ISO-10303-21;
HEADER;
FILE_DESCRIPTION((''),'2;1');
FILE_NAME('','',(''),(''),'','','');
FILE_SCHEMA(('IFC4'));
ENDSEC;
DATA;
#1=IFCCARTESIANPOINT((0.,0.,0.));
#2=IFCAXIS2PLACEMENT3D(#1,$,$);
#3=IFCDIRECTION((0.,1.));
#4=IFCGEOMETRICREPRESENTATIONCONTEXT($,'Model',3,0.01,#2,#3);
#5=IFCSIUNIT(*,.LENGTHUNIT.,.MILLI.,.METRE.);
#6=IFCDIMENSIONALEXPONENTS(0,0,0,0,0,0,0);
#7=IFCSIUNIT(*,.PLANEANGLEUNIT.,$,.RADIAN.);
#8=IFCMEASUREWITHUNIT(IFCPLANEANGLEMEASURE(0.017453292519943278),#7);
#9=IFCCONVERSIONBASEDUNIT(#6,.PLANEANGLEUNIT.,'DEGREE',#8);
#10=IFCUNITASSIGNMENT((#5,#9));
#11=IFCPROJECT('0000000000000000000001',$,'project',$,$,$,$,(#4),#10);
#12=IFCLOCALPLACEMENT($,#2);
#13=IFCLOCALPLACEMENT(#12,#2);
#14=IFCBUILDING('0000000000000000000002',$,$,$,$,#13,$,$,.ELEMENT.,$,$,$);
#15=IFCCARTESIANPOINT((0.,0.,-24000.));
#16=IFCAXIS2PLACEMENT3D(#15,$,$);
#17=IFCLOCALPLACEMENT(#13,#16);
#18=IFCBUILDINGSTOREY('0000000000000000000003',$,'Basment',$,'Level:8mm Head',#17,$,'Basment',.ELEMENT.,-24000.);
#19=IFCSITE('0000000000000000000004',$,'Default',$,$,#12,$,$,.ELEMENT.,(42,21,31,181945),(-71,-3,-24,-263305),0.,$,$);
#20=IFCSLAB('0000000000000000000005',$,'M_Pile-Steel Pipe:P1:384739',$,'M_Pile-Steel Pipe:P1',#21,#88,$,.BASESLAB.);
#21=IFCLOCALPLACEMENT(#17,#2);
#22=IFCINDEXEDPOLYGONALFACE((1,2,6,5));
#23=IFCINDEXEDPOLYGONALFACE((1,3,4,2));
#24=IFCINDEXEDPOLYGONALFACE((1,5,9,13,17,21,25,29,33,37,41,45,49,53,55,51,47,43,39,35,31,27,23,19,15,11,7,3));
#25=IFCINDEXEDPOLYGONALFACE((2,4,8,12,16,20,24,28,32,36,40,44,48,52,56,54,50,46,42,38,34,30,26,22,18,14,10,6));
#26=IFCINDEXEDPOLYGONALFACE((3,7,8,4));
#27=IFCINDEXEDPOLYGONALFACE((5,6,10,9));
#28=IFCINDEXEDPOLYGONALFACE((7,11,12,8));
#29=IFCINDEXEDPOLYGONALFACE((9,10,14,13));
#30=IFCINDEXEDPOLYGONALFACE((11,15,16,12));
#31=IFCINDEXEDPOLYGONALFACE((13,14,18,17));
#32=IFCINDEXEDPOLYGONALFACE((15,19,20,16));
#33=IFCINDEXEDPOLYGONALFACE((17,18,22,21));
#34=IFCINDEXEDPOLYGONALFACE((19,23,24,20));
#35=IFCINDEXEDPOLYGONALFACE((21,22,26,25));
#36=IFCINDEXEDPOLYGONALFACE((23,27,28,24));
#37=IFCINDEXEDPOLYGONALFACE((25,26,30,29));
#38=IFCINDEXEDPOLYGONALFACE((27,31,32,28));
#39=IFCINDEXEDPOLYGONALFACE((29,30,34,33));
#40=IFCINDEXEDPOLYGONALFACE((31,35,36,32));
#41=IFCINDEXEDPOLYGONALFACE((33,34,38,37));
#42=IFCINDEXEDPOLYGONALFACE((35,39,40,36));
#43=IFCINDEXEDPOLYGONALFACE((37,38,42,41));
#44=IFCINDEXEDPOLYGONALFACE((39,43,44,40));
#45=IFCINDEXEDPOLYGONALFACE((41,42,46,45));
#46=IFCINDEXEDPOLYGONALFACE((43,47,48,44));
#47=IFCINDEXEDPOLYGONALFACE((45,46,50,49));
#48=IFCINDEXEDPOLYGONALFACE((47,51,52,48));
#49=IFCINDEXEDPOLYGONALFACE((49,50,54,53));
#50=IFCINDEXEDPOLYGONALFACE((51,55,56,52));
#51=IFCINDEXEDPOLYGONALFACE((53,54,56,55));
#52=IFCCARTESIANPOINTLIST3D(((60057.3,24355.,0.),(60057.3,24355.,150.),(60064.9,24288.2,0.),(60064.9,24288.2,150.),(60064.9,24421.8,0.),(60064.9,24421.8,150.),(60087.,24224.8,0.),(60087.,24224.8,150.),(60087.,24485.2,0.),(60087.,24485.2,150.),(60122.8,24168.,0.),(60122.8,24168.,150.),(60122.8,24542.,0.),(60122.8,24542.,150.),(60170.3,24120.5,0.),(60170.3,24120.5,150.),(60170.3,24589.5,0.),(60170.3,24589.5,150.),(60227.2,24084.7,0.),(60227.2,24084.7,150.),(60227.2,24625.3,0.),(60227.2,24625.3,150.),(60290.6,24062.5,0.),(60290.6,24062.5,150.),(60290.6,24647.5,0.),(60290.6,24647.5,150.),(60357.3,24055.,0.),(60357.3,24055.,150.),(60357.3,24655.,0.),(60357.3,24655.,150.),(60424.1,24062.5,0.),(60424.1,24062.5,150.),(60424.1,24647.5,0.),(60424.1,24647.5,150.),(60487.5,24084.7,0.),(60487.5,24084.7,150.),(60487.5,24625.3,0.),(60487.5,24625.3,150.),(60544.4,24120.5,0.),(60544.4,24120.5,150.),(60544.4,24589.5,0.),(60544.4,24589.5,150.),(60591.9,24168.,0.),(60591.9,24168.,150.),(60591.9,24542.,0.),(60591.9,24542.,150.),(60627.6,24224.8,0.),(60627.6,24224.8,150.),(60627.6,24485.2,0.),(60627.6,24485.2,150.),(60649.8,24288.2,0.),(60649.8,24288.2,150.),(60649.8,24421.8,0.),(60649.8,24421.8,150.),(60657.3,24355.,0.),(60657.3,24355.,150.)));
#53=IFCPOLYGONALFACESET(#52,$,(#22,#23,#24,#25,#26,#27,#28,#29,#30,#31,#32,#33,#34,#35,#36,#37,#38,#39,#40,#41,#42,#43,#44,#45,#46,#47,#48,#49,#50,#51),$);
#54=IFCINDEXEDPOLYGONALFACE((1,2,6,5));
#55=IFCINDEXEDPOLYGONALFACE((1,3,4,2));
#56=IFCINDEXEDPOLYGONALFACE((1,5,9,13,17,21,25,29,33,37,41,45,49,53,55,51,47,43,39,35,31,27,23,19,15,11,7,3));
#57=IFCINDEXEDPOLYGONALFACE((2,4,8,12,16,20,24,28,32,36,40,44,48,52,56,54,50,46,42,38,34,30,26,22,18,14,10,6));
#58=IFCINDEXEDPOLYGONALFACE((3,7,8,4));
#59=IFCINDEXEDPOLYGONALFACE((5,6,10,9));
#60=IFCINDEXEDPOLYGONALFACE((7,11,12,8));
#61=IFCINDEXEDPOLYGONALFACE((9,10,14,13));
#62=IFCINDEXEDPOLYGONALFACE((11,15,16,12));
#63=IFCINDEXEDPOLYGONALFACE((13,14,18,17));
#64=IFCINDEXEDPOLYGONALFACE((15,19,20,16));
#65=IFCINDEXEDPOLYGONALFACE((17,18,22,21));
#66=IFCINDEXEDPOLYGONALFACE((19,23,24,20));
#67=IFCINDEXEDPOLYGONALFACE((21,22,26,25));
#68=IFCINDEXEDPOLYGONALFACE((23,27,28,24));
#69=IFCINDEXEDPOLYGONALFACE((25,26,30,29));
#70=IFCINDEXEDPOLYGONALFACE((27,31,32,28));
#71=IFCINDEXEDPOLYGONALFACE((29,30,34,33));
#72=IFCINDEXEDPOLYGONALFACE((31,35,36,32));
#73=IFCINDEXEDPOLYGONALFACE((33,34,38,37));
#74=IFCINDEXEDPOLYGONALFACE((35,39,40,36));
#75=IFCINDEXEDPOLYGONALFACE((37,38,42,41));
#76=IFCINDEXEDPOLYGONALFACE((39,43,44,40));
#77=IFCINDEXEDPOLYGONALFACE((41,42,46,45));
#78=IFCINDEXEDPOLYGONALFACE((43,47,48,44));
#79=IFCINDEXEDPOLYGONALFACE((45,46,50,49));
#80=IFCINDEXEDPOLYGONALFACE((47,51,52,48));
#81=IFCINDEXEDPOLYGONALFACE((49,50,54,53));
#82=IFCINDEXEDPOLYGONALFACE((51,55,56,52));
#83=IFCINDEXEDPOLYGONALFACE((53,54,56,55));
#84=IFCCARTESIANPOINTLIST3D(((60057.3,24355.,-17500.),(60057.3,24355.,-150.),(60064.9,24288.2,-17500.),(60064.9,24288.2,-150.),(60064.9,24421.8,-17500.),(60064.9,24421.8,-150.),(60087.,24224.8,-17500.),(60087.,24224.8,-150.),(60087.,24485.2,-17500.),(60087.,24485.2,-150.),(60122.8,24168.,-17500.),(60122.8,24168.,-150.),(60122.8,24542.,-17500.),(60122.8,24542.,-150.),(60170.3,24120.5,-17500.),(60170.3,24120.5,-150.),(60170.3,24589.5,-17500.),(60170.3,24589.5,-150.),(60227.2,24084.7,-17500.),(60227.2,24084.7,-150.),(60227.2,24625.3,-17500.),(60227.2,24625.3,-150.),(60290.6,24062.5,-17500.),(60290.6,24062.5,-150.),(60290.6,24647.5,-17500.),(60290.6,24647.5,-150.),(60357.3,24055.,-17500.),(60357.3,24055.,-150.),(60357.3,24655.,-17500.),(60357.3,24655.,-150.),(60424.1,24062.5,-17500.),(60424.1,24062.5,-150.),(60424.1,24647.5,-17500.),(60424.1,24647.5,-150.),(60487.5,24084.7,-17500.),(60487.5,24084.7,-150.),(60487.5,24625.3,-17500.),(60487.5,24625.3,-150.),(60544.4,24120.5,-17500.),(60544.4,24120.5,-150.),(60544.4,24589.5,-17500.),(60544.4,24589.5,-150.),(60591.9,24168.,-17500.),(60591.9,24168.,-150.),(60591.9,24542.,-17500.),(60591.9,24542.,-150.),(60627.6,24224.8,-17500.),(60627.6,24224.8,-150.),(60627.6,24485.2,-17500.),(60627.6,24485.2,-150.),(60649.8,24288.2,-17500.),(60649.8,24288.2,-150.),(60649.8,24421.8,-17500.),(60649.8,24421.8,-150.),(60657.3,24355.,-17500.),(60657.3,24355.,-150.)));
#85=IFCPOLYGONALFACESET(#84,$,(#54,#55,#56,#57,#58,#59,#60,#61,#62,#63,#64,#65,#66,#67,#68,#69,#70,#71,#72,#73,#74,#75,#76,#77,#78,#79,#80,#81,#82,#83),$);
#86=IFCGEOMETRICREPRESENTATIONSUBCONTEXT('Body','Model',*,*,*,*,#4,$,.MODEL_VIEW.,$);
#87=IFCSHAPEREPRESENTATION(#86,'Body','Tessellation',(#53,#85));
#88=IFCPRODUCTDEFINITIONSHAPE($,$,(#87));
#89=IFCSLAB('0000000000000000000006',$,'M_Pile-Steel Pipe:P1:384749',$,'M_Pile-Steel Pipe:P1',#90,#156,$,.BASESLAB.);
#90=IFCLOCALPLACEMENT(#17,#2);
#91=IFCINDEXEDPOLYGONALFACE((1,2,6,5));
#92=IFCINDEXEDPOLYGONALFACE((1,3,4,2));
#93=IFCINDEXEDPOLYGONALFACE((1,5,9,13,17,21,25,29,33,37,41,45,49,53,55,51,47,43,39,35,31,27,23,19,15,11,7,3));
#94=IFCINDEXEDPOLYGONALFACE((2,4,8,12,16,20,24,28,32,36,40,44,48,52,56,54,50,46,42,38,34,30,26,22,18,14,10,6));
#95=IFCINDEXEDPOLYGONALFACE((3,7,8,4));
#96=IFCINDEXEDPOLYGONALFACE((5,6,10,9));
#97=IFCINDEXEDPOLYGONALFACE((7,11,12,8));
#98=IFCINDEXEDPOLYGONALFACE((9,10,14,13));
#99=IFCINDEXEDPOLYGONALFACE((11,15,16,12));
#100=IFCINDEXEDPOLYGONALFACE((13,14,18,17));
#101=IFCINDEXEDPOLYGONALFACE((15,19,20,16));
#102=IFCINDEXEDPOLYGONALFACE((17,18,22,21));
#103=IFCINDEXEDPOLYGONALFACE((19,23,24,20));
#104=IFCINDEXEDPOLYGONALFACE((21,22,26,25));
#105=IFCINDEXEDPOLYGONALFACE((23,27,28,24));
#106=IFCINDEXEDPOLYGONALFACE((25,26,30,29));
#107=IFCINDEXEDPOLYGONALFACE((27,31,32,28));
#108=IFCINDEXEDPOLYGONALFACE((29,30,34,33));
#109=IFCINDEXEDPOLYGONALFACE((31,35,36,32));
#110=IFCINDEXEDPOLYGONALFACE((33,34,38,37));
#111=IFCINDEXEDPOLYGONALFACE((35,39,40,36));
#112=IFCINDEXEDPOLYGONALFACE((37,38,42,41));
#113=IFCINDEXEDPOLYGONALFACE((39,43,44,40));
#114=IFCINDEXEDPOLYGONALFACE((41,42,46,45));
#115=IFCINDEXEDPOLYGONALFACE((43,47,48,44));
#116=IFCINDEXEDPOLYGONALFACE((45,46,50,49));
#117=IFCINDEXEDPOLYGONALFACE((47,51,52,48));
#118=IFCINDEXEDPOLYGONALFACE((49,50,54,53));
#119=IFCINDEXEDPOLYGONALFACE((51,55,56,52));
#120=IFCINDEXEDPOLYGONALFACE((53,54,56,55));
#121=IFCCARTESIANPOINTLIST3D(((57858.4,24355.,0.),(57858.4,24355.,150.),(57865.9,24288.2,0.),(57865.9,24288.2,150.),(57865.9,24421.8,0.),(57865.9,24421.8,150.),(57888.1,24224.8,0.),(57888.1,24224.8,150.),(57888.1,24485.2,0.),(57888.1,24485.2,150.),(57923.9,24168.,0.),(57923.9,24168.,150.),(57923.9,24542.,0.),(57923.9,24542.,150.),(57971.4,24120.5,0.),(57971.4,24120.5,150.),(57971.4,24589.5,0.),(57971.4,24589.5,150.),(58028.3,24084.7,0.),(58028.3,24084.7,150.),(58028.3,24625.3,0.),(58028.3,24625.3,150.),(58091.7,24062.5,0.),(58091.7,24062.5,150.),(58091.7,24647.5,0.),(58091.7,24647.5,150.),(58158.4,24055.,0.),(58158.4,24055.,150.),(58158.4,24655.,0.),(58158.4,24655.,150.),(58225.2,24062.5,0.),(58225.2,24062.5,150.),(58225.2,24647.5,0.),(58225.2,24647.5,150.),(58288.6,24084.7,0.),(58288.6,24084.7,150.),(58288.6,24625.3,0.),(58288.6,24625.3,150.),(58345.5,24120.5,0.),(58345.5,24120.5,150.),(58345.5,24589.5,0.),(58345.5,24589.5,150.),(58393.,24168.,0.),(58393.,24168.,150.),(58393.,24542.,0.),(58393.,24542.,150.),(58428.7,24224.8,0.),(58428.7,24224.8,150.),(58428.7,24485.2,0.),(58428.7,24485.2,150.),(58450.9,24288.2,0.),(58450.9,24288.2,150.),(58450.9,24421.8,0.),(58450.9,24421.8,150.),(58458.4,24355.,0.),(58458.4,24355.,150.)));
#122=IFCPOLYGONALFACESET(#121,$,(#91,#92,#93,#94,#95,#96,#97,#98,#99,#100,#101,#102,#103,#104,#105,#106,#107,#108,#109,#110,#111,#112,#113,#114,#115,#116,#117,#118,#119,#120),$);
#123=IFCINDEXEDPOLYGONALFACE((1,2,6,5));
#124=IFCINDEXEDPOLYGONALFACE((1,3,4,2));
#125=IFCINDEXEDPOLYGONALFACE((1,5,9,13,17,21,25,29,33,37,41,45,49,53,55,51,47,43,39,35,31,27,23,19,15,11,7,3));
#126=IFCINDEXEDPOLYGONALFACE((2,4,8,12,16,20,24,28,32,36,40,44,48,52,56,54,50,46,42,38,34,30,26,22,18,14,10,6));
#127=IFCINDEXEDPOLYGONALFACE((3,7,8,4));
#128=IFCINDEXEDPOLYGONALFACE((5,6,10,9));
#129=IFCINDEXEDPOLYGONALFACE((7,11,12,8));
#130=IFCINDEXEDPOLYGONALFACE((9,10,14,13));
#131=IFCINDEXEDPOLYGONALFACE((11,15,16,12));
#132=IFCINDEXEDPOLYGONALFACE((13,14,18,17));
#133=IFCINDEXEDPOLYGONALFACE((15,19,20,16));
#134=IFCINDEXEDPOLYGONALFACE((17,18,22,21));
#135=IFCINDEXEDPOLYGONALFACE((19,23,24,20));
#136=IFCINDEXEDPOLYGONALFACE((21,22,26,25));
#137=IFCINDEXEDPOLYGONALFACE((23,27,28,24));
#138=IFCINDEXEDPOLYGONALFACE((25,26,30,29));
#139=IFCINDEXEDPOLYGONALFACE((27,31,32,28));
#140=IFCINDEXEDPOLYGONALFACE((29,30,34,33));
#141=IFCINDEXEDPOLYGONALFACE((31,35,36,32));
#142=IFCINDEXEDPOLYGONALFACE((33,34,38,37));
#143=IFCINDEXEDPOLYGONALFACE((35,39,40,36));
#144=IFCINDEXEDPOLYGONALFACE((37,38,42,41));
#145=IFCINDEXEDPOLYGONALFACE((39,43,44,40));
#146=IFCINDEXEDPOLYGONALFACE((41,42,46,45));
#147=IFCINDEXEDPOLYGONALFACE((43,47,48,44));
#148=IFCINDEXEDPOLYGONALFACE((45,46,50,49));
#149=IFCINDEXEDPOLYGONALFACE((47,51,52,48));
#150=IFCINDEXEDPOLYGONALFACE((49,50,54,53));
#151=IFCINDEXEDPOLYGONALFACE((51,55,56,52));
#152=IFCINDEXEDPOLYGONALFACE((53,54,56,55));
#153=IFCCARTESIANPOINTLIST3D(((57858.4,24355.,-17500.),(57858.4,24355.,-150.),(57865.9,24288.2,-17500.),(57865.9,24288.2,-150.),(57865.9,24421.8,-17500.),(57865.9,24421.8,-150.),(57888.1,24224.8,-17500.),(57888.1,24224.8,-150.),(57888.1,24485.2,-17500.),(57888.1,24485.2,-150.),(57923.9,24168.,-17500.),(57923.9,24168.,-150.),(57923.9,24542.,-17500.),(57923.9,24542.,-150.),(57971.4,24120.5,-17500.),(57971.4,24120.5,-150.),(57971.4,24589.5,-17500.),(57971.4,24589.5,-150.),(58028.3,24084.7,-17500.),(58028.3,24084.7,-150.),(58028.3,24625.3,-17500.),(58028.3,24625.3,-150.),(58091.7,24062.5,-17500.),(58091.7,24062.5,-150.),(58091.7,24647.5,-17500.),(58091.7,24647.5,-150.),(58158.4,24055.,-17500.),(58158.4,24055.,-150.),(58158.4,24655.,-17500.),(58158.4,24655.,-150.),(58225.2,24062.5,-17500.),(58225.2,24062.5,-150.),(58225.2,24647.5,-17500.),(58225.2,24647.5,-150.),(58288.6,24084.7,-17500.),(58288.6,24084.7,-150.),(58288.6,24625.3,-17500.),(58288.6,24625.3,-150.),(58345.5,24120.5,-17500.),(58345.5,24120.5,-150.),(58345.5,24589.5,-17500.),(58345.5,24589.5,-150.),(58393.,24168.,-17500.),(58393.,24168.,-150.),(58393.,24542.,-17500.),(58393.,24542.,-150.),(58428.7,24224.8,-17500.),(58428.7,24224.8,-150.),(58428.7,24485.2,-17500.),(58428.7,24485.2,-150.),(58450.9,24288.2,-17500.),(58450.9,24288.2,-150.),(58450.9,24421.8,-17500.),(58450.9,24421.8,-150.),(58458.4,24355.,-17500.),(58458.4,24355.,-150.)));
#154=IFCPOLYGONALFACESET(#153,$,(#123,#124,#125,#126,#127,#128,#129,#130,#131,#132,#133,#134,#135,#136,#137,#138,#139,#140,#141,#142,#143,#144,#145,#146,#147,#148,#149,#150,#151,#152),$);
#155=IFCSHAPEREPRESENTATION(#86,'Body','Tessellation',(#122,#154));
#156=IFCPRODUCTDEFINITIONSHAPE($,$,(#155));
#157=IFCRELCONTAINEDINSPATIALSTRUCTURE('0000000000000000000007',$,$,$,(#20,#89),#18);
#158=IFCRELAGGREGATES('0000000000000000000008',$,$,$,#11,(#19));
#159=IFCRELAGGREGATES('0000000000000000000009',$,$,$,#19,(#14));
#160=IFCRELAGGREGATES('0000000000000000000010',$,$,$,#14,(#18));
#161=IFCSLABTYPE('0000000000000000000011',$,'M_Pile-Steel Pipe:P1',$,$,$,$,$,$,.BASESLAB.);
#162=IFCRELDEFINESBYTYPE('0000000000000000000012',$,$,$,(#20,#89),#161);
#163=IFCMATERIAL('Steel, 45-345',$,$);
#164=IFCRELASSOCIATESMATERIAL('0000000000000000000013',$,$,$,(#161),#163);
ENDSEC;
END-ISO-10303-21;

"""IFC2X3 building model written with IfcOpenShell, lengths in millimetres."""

from ifc_helpers import new_model, entity, si_unit, converted_unit, direction, frame, origin, origin_2d_with_axis, place, context, subcontext, project, spatial, circle, extrude, material, type_object, element, save


model = new_model("IFC2X3")

# Units and contexts
model_context = context("Model", 3, precision=0.01, world=origin(), true_north=direction((0.0, 1.0)))
body_context = subcontext(model_context, "Body", "Model", "MODEL_VIEW")
ifc_project = project(units=[si_unit("LENGTHUNIT", "METRE", prefix="MILLI"), converted_unit("PLANEANGLEUNIT", "DEGREE", entity("IfcPlaneAngleMeasure", 0.017453292519943278), si_unit("PLANEANGLEUNIT", "RADIAN"), dimensions=[0, 0, 0, 0, 0, 0, 0])], contexts=[model_context])

# Site, building, storey
site_placement = place(None, origin())
site = spatial("IfcSite", under=ifc_project, at=site_placement, Name="Default", CompositionType="ELEMENT", RefLatitude=(42, 21, 31, 181945), RefLongitude=(-71, -3, -24, -263305), RefElevation=0.0)
building_placement = place(site_placement, origin())
building = spatial("IfcBuilding", under=site, at=building_placement, CompositionType="ELEMENT")
storey_placement = place(building_placement, frame((0.0, 0.0, -24000.0)))
storey = spatial("IfcBuildingStorey", under=building, at=storey_placement, Name="Basment", ObjectType="Level:8mm Head", LongName="Basment", CompositionType="ELEMENT", Elevation=-24000.0)

# Slabs
ifc_material_1 = material(Name="Steel, 45-345")
slab_type_1 = type_object("IfcSlabType", Name="M_Pile-Steel Pipe:P1", PredefinedType="BASESLAB", material=ifc_material_1)
slab_1_placement = place(storey_placement, origin())
element("IfcSlab", 1, at=slab_1_placement, inside=storey, type_object=slab_type_1, Name="M_Pile-Steel Pipe:P1:384739", ObjectType="M_Pile-Steel Pipe:P1", PredefinedType="BASESLAB", context=body_context, shape_type="SweptSolid", body=[
    extrude(circle(Radius=300.0, at=origin_2d_with_axis()), frame((60357.3, 24355.0, 0.0), z_axis=(0.0, 0.0, 1.0), x_axis=(0.0, 1.0, 0.0)), (0.0, 0.0, 1.0), 150.0),
    extrude(circle(Radius=300.0, at=origin_2d_with_axis()), frame((60357.3, 24355.0, -17500.0), z_axis=(0.0, 0.0, 1.0), x_axis=(0.0, 1.0, 0.0)), (0.0, 0.0, 1.0), 17350.0),
])
slab_2_placement = place(storey_placement, origin())
element("IfcSlab", 2, at=slab_2_placement, inside=storey, type_object=slab_type_1, Name="M_Pile-Steel Pipe:P1:384749", ObjectType="M_Pile-Steel Pipe:P1", PredefinedType="BASESLAB", context=body_context, shape_type="SweptSolid", body=[
    extrude(circle(Radius=300.0, at=origin_2d_with_axis()), frame((58158.4, 24355.0, 0.0), z_axis=(0.0, 0.0, 1.0), x_axis=(0.0, 1.0, 0.0)), (0.0, 0.0, 1.0), 150.0),
    extrude(circle(Radius=300.0, at=origin_2d_with_axis()), frame((58158.4, 24355.0, -17500.0), z_axis=(0.0, 0.0, 1.0), x_axis=(0.0, 1.0, 0.0)), (0.0, 0.0, 1.0), 17350.0),
])

save(model, "model.ifc")
